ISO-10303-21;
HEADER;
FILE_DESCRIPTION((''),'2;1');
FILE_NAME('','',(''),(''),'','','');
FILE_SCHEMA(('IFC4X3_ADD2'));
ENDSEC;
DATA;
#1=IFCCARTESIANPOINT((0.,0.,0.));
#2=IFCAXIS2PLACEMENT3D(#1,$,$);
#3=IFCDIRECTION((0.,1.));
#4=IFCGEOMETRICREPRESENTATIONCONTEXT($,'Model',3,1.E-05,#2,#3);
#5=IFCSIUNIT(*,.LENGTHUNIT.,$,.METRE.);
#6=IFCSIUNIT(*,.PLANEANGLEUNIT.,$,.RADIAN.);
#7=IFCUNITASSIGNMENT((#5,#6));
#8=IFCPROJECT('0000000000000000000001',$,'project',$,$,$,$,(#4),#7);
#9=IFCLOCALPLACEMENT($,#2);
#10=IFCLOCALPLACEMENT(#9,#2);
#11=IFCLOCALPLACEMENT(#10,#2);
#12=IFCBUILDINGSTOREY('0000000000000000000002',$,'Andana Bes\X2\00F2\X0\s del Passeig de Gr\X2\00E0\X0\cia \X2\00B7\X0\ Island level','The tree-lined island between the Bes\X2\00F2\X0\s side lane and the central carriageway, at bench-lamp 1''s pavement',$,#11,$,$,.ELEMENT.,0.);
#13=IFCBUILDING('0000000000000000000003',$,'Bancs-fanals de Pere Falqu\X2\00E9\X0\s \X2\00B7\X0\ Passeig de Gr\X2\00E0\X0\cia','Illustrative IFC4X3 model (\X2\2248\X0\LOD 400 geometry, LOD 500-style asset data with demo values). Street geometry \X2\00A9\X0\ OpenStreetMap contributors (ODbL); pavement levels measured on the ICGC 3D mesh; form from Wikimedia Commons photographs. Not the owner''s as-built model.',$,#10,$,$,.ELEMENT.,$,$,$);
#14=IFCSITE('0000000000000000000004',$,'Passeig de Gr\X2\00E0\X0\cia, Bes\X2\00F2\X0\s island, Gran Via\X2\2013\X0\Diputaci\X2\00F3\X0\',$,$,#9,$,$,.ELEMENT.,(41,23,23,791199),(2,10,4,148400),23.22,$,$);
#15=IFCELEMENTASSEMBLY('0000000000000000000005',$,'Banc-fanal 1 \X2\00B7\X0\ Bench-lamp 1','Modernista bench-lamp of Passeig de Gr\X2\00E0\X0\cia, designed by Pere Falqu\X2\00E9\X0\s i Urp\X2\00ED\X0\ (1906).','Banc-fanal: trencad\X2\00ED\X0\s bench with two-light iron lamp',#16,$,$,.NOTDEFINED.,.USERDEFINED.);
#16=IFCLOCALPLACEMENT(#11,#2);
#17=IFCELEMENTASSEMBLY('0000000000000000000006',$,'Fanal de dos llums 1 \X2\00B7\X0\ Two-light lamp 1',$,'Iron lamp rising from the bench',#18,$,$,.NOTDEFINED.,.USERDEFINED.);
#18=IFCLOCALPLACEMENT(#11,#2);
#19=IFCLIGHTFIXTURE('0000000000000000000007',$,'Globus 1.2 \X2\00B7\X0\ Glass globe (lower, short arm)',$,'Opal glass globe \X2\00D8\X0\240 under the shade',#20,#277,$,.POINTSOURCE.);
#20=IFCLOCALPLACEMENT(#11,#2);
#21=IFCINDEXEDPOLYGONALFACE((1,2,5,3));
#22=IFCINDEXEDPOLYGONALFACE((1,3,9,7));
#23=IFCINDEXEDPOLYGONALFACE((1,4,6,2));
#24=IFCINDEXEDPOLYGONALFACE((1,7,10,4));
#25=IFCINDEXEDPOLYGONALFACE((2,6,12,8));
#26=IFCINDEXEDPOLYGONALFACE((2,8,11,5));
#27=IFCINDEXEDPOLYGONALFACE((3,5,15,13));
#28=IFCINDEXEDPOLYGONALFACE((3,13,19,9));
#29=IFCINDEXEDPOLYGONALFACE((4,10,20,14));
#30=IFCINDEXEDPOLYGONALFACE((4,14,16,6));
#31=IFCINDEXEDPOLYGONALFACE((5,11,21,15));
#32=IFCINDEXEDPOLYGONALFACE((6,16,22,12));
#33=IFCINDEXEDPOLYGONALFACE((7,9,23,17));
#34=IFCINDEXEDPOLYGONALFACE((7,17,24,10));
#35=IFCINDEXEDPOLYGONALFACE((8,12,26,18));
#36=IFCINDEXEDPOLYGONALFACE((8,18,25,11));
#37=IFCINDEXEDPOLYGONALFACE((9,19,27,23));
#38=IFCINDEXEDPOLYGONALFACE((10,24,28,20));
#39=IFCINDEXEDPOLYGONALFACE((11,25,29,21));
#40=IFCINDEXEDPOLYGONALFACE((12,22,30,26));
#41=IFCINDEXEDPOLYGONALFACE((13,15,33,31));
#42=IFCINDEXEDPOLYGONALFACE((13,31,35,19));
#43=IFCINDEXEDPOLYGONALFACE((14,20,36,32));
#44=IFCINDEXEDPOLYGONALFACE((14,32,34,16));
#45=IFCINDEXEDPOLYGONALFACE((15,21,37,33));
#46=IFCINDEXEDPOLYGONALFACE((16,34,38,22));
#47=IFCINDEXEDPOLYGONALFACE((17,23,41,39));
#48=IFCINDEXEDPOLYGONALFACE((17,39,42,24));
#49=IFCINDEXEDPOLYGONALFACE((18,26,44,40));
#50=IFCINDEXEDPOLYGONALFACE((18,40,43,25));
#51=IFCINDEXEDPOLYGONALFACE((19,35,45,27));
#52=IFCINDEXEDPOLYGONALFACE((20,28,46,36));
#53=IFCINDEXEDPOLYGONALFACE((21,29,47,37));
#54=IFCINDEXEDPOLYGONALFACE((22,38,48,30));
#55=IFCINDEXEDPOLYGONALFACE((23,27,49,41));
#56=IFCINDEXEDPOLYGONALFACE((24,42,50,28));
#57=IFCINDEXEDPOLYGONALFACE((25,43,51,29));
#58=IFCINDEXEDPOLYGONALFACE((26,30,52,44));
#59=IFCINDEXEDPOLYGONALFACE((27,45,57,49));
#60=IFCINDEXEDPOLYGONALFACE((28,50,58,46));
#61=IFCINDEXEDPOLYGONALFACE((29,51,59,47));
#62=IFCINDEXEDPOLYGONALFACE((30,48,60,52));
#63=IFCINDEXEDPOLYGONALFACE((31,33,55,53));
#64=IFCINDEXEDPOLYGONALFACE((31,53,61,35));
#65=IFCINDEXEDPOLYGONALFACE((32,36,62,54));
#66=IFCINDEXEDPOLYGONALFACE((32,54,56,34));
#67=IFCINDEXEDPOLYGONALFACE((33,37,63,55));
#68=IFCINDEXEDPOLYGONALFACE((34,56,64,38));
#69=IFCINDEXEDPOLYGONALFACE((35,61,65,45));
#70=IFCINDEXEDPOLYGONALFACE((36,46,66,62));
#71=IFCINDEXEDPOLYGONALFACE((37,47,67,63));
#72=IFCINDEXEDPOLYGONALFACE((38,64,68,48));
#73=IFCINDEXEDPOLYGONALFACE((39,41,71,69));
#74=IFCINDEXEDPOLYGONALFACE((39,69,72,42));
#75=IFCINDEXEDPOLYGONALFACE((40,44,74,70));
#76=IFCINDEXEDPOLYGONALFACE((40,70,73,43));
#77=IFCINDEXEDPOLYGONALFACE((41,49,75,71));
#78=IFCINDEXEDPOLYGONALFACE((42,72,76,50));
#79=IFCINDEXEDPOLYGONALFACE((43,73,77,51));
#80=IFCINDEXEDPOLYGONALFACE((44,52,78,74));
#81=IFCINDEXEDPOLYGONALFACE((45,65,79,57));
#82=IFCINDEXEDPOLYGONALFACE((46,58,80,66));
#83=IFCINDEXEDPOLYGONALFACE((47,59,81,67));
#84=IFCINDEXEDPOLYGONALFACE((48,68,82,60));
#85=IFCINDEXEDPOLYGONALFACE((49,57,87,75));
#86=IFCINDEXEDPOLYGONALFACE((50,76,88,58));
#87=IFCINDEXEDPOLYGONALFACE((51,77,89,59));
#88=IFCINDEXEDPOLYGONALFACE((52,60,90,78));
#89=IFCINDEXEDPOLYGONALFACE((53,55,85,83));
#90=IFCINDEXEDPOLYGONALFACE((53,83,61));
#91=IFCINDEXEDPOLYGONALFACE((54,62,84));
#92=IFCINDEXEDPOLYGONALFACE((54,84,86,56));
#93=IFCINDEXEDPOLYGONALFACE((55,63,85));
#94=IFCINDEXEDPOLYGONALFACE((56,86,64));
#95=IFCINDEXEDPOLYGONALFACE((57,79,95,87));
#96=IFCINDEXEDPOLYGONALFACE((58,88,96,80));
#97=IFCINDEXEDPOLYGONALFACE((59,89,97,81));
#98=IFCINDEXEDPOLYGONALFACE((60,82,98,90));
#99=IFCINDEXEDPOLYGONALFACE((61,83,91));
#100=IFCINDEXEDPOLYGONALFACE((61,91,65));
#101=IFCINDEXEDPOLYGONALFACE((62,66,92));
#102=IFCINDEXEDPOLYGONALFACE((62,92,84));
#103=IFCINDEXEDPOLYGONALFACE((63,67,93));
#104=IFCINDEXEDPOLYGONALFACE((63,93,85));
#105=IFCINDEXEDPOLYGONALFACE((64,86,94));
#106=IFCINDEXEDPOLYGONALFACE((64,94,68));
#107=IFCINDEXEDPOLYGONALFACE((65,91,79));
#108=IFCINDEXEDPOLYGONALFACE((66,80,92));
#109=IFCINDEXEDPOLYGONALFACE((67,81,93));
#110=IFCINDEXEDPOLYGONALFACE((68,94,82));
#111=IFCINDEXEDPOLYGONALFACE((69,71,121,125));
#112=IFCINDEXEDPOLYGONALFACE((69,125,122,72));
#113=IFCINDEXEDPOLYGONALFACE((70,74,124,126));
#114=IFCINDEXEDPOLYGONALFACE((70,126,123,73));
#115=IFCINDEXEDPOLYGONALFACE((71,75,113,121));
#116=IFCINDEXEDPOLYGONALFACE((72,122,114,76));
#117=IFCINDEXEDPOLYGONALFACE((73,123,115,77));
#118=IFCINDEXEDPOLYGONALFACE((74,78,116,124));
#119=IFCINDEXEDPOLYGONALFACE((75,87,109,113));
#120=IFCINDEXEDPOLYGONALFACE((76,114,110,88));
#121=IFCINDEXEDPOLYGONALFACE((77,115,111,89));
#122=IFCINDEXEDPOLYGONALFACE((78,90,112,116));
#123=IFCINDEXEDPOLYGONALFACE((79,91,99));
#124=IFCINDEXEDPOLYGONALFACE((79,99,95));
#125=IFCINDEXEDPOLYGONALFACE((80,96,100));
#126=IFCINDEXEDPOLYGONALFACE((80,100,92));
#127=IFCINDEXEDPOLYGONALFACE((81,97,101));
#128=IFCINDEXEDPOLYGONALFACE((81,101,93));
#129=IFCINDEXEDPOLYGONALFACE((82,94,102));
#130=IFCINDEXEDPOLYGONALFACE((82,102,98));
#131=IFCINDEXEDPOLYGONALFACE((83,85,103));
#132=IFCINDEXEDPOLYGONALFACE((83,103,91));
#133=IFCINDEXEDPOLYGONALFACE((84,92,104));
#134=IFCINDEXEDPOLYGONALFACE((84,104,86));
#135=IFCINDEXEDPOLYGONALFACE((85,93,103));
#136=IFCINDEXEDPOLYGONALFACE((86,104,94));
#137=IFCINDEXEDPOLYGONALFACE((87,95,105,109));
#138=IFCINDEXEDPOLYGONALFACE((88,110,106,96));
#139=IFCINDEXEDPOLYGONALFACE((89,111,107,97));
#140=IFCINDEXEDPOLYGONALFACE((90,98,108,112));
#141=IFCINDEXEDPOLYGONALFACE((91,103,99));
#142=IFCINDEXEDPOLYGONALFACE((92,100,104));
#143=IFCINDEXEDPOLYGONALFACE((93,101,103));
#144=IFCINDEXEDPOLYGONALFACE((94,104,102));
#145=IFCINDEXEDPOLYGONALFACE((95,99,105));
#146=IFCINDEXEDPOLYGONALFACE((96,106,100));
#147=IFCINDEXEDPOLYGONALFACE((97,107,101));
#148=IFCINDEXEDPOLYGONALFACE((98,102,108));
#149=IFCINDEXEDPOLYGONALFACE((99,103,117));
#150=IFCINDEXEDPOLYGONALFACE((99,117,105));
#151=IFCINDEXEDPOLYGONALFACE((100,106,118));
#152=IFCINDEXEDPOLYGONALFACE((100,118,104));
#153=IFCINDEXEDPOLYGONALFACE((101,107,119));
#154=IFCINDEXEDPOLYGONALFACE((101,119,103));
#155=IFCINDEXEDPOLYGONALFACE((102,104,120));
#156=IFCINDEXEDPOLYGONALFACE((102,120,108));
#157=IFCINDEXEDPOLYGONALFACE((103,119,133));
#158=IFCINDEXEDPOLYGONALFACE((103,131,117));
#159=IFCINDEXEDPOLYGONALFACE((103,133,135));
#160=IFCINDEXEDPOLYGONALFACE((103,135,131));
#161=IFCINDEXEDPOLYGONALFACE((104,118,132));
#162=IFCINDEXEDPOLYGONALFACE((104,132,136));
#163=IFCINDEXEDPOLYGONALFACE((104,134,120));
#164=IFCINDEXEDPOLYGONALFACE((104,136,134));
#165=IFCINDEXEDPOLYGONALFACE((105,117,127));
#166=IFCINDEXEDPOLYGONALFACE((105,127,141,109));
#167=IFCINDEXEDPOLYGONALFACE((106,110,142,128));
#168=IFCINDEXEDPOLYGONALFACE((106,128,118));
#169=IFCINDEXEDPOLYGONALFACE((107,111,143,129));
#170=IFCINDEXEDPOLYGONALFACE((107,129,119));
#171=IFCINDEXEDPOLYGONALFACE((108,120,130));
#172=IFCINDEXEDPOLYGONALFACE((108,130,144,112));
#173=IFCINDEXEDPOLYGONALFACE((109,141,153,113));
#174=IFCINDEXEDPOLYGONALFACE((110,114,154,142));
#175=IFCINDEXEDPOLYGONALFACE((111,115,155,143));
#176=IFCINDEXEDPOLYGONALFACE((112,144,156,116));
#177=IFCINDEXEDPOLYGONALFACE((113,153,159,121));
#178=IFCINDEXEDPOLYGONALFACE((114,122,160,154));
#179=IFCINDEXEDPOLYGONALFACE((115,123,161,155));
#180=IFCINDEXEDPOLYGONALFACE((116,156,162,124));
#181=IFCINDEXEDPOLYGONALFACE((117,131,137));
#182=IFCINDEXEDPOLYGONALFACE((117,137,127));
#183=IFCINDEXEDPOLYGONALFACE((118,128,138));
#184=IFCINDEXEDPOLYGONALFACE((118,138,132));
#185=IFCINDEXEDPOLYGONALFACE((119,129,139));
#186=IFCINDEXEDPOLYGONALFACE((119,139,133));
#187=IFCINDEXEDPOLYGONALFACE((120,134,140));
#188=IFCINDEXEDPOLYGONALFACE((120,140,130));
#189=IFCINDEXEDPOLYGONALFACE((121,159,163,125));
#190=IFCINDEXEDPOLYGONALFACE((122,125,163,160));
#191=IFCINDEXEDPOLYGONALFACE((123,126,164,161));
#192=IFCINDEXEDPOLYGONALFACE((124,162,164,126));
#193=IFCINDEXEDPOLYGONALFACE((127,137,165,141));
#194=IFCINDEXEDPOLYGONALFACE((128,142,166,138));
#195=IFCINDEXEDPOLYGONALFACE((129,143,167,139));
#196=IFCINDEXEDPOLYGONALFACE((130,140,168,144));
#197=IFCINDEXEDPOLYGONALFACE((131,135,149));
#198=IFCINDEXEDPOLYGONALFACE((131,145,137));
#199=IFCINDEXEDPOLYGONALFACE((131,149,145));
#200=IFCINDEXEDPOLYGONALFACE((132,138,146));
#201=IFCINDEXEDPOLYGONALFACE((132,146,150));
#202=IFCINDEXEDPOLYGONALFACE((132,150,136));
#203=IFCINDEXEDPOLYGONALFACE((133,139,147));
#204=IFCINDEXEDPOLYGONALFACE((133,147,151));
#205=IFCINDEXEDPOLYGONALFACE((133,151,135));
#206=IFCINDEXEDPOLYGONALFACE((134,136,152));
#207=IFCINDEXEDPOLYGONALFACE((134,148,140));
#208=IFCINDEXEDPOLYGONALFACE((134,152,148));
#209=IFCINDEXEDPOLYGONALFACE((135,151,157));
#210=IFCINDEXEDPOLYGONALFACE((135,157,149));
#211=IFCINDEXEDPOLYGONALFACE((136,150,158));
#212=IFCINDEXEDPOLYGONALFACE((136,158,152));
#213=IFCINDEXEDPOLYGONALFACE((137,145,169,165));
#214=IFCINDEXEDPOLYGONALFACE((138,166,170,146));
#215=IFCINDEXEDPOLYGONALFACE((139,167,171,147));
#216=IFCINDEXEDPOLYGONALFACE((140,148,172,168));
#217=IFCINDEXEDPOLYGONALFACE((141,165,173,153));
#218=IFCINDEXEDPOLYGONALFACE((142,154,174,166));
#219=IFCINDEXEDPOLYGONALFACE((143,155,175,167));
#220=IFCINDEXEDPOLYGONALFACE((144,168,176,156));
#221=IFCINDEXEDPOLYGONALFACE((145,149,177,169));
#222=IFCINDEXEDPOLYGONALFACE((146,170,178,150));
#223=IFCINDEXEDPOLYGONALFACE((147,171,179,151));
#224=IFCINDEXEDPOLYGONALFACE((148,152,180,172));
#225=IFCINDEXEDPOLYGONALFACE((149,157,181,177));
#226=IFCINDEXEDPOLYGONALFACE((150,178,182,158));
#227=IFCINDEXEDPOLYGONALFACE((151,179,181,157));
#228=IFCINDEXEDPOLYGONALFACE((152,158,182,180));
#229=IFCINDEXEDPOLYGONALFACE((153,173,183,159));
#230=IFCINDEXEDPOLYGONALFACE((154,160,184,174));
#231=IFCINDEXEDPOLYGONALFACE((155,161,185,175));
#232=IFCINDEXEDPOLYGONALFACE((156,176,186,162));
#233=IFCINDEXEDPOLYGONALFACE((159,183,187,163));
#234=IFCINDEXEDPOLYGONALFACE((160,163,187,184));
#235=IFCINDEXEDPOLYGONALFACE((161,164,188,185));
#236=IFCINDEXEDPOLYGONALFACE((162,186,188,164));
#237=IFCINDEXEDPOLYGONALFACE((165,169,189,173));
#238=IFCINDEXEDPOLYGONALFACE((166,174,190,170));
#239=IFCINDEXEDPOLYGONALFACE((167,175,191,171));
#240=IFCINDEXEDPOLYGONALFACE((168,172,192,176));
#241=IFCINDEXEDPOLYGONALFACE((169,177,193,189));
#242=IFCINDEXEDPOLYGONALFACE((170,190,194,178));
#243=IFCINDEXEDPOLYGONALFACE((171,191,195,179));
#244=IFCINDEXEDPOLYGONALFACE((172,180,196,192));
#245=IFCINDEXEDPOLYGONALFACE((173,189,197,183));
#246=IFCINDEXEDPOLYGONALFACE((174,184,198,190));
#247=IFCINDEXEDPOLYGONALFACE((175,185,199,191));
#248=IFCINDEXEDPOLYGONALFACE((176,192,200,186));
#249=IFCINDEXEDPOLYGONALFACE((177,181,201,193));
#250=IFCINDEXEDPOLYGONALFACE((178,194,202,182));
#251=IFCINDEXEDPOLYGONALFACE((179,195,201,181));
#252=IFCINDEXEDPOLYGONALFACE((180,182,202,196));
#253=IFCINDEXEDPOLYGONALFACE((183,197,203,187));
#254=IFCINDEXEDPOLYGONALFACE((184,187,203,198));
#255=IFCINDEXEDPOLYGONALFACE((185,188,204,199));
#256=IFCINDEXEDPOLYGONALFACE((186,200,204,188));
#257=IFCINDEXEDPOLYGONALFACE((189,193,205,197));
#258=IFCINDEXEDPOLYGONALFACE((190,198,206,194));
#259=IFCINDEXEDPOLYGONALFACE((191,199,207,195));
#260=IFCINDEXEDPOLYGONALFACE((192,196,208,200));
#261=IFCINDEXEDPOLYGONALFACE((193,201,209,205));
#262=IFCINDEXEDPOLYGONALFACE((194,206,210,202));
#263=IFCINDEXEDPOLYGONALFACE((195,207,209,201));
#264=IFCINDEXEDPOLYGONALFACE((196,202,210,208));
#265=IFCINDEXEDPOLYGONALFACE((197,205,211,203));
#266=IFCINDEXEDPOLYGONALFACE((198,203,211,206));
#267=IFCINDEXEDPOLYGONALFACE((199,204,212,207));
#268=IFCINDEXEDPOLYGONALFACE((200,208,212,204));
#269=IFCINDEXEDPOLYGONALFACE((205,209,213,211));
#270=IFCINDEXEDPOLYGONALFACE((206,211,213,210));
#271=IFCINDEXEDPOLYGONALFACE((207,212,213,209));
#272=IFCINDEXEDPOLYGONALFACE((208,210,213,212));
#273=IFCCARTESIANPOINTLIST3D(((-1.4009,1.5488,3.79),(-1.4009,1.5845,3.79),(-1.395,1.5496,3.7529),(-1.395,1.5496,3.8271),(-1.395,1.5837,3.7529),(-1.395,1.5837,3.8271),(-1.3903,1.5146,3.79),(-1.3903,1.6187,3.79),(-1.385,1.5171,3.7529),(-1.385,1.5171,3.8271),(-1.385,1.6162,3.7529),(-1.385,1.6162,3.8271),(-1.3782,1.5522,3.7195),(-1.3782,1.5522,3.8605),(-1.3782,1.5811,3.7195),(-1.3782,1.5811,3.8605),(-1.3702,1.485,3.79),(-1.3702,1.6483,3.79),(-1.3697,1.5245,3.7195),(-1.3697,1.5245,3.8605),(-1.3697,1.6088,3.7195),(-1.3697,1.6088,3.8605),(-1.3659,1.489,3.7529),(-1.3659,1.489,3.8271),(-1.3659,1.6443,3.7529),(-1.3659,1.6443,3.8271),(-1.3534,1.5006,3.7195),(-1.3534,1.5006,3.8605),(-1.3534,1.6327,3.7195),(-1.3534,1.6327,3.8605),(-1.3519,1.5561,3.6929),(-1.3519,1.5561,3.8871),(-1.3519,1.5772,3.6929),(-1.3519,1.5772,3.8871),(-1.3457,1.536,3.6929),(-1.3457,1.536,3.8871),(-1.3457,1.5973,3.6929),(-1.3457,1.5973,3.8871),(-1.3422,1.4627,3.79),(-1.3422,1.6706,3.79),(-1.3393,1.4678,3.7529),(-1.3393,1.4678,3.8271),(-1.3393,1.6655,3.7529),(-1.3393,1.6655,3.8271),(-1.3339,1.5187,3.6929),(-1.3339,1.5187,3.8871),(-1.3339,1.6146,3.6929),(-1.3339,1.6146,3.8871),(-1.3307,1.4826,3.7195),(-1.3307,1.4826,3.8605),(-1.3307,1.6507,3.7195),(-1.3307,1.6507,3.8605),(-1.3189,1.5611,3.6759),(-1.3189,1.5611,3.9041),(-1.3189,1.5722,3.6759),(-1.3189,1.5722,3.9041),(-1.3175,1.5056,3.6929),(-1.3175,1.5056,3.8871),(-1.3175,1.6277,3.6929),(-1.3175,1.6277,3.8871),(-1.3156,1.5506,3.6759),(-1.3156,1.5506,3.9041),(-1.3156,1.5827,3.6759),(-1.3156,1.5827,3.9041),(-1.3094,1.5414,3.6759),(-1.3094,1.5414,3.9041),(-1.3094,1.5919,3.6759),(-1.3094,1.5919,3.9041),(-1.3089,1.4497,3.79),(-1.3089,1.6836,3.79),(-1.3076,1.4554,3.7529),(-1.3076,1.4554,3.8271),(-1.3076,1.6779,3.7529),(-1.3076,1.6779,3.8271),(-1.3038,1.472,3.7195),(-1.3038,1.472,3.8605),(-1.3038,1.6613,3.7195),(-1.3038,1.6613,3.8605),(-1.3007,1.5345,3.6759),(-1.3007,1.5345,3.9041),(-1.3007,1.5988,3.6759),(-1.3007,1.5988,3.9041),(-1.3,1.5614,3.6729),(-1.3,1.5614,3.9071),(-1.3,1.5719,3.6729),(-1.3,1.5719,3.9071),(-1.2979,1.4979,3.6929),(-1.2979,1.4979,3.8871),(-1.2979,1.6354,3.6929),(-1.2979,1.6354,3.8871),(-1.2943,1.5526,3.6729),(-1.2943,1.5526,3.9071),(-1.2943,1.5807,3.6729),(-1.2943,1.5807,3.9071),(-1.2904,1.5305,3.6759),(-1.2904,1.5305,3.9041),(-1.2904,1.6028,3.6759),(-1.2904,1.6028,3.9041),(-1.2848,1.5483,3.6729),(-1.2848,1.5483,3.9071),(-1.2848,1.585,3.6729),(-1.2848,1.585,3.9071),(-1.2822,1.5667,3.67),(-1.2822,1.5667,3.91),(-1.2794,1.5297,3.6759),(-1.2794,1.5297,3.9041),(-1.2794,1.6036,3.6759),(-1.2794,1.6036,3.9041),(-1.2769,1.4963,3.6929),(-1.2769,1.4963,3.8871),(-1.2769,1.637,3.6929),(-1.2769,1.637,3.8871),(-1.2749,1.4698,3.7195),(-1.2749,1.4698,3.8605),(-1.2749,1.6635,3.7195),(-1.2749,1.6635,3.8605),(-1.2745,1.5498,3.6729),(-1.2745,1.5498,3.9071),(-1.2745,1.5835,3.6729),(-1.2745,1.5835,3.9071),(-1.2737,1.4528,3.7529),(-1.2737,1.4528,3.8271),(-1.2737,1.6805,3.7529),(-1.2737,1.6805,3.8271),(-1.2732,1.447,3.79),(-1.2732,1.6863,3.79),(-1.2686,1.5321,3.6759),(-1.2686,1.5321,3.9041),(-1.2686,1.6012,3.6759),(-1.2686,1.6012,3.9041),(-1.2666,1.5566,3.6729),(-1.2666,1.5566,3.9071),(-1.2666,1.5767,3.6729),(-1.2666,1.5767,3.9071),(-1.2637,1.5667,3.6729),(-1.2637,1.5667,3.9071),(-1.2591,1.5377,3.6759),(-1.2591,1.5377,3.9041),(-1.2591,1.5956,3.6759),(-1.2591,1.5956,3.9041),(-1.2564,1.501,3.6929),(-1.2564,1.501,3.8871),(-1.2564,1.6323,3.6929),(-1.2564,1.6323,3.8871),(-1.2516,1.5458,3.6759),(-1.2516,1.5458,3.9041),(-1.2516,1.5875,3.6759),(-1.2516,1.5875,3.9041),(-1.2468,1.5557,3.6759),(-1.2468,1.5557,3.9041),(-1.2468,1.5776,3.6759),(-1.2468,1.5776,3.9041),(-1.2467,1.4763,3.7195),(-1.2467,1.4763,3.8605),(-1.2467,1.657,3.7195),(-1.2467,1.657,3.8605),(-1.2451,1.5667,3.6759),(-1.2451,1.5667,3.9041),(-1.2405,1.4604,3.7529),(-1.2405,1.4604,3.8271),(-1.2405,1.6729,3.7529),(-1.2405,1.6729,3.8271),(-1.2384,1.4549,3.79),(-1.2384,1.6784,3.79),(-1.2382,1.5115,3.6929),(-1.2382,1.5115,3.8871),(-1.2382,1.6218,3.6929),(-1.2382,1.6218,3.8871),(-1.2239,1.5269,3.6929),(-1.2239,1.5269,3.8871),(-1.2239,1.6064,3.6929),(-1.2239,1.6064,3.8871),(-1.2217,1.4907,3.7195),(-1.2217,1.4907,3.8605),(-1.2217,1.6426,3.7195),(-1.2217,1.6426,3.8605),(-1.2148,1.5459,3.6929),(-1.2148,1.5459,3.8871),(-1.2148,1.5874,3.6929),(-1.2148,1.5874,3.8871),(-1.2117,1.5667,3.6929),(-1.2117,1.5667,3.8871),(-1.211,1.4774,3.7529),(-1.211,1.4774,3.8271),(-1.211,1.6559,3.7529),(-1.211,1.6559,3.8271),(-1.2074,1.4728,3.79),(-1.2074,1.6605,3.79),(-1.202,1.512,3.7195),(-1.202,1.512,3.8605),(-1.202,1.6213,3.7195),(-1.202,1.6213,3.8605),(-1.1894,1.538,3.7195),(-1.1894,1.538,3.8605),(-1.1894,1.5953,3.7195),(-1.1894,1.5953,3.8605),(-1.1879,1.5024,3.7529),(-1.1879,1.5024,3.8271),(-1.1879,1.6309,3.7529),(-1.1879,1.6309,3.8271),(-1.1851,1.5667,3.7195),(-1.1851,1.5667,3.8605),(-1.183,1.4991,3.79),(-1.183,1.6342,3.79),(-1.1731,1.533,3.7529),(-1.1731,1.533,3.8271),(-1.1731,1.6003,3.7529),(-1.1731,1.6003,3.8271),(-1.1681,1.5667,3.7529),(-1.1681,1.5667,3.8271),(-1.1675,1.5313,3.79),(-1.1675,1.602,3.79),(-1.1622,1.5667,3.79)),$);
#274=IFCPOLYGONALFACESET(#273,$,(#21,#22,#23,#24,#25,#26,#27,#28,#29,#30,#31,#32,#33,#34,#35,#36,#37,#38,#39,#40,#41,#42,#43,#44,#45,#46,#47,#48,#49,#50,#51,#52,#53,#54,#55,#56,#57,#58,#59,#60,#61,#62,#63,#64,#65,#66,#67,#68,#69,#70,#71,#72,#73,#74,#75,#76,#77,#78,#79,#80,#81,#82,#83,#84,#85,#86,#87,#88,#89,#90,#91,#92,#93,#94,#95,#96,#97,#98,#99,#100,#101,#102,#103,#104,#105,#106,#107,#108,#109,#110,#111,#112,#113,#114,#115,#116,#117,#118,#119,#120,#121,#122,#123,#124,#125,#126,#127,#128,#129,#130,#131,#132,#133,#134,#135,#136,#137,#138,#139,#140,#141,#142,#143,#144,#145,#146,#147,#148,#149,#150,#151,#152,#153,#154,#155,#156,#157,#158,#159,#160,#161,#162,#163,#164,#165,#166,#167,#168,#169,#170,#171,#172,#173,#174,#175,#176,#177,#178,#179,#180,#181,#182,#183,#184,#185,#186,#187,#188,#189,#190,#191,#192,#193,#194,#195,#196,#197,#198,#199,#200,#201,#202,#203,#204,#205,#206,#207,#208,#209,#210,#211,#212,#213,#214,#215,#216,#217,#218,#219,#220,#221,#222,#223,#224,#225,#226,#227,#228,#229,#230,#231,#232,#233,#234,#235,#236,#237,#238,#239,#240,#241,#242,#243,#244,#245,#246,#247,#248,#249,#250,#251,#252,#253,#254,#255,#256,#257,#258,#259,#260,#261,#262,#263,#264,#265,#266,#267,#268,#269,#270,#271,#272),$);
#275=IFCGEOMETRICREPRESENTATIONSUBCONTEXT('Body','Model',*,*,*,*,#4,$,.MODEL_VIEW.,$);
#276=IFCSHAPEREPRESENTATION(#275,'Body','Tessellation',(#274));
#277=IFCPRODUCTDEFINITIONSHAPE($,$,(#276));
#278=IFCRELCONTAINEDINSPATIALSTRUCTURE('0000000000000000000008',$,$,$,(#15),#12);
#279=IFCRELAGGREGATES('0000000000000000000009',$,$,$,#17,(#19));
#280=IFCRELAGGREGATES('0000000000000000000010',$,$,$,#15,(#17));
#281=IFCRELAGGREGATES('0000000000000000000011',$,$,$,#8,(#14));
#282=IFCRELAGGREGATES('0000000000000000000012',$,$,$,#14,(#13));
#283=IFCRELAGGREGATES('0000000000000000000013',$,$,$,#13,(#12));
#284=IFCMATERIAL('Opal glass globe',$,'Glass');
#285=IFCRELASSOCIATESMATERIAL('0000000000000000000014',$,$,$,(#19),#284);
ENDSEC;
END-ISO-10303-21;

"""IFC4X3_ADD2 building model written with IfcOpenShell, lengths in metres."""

from ifc_helpers import new_model, entity, si_unit, direction, origin, place, context, subcontext, project, spatial, material, element, aggregate, save


model = new_model("IFC4X3_ADD2")

# Units and contexts
model_context = context("Model", 3, precision=1e-05, world=origin(), true_north=direction((0.0, 1.0)))
body_context = subcontext(model_context, "Body", "Model", "MODEL_VIEW")
ifc_project = project(units=[si_unit("LENGTHUNIT", "METRE"), si_unit("PLANEANGLEUNIT", "RADIAN")], contexts=[model_context])

# Site, building, storey
site_placement = place(None, origin())
site = spatial("IfcSite", under=ifc_project, at=site_placement, Name="Passeig de Gràcia, Besòs island, Gran Via–Diputació", CompositionType="ELEMENT", RefLatitude=(41, 23, 23, 791199), RefLongitude=(2, 10, 4, 148400), RefElevation=23.22)
building_placement = place(site_placement, origin())
building = spatial("IfcBuilding", under=site, at=building_placement, Name="Bancs-fanals de Pere Falqués · Passeig de Gràcia", Description="Illustrative IFC4X3 model (≈LOD 400 geometry, LOD 500-style asset data with demo values). Street geometry © OpenStreetMap contributors (ODbL); pavement levels measured on the ICGC 3D mesh; form from Wikimedia Commons photographs. Not the owner's as-built model.", CompositionType="ELEMENT")
storey_placement = place(building_placement, origin())
storey = spatial("IfcBuildingStorey", under=building, at=storey_placement, Name="Andana Besòs del Passeig de Gràcia · Island level", Description="The tree-lined island between the Besòs side lane and the central carriageway, at bench-lamp 1's pavement", CompositionType="ELEMENT", Elevation=0.0)

# Element assembly
assembly_1_placement = place(building_placement, origin())
assembly_1 = element("IfcElementAssembly", 1, at=assembly_1_placement, inside=storey, Name="Banc-fanal 1 · Bench-lamp 1", Description="Modernista bench-lamp of Passeig de Gràcia, designed by Pere Falqués i Urpí (1906).", ObjectType="Banc-fanal: trencadís bench with two-light iron lamp", AssemblyPlace="NOTDEFINED", PredefinedType="USERDEFINED")

# Element assembly
assembly_2_placement = place(building_placement, origin())
assembly_2 = element("IfcElementAssembly", 2, at=assembly_2_placement, Name="Fanal de dos llums 1 · Two-light lamp 1", ObjectType="Iron lamp rising from the bench", AssemblyPlace="NOTDEFINED", PredefinedType="USERDEFINED")

# Shared definitions
ifc_material_1 = material(Name="Opal glass globe", Category="Glass")

# Light fixture
light_fixture_1_placement = place(building_placement, origin())
light_fixture_1 = element("IfcLightFixture", 3, at=light_fixture_1_placement, material=ifc_material_1, Name="Globus 1.2 · Glass globe (lower, short arm)", ObjectType="Opal glass globe Ø240 under the shade", PredefinedType="POINTSOURCE", context=body_context, shape_type="SweptSolid", body=[
    entity("IfcRevolvedAreaSolid", entity("IfcArbitraryClosedProfileDef", "AREA", None, entity("IfcPolyline", [entity("IfcCartesianPoint", [0.0, -0.12]), entity("IfcCartesianPoint", [0.0371, -0.1141]), entity("IfcCartesianPoint", [0.0705, -0.0971]), entity("IfcCartesianPoint", [0.0971, -0.0705]), entity("IfcCartesianPoint", [0.1141, -0.0371]), entity("IfcCartesianPoint", [0.12, 0.0]), entity("IfcCartesianPoint", [0.1141, 0.0371]), entity("IfcCartesianPoint", [0.0971, 0.0705]), entity("IfcCartesianPoint", [0.0705, 0.0971]), entity("IfcCartesianPoint", [0.0371, 0.1141]), entity("IfcCartesianPoint", [0.0, 0.12]), entity("IfcCartesianPoint", [0.0, -0.12])])), entity("IfcAxis2Placement3D", entity("IfcCartesianPoint", [-1.2822, 1.5667, 3.79]), entity("IfcDirection", [0.0, -1.0, 0.0]), entity("IfcDirection", [1.0, 0.0, 0.0])), entity("IfcAxis1Placement", entity("IfcCartesianPoint", [0.0, 0.0, 0.0]), entity("IfcDirection", [0.0, 1.0, 0.0])), 6.283185),
])

aggregate(assembly_2, [light_fixture_1])

aggregate(assembly_1, [assembly_2])

save(model, "model.ifc")
